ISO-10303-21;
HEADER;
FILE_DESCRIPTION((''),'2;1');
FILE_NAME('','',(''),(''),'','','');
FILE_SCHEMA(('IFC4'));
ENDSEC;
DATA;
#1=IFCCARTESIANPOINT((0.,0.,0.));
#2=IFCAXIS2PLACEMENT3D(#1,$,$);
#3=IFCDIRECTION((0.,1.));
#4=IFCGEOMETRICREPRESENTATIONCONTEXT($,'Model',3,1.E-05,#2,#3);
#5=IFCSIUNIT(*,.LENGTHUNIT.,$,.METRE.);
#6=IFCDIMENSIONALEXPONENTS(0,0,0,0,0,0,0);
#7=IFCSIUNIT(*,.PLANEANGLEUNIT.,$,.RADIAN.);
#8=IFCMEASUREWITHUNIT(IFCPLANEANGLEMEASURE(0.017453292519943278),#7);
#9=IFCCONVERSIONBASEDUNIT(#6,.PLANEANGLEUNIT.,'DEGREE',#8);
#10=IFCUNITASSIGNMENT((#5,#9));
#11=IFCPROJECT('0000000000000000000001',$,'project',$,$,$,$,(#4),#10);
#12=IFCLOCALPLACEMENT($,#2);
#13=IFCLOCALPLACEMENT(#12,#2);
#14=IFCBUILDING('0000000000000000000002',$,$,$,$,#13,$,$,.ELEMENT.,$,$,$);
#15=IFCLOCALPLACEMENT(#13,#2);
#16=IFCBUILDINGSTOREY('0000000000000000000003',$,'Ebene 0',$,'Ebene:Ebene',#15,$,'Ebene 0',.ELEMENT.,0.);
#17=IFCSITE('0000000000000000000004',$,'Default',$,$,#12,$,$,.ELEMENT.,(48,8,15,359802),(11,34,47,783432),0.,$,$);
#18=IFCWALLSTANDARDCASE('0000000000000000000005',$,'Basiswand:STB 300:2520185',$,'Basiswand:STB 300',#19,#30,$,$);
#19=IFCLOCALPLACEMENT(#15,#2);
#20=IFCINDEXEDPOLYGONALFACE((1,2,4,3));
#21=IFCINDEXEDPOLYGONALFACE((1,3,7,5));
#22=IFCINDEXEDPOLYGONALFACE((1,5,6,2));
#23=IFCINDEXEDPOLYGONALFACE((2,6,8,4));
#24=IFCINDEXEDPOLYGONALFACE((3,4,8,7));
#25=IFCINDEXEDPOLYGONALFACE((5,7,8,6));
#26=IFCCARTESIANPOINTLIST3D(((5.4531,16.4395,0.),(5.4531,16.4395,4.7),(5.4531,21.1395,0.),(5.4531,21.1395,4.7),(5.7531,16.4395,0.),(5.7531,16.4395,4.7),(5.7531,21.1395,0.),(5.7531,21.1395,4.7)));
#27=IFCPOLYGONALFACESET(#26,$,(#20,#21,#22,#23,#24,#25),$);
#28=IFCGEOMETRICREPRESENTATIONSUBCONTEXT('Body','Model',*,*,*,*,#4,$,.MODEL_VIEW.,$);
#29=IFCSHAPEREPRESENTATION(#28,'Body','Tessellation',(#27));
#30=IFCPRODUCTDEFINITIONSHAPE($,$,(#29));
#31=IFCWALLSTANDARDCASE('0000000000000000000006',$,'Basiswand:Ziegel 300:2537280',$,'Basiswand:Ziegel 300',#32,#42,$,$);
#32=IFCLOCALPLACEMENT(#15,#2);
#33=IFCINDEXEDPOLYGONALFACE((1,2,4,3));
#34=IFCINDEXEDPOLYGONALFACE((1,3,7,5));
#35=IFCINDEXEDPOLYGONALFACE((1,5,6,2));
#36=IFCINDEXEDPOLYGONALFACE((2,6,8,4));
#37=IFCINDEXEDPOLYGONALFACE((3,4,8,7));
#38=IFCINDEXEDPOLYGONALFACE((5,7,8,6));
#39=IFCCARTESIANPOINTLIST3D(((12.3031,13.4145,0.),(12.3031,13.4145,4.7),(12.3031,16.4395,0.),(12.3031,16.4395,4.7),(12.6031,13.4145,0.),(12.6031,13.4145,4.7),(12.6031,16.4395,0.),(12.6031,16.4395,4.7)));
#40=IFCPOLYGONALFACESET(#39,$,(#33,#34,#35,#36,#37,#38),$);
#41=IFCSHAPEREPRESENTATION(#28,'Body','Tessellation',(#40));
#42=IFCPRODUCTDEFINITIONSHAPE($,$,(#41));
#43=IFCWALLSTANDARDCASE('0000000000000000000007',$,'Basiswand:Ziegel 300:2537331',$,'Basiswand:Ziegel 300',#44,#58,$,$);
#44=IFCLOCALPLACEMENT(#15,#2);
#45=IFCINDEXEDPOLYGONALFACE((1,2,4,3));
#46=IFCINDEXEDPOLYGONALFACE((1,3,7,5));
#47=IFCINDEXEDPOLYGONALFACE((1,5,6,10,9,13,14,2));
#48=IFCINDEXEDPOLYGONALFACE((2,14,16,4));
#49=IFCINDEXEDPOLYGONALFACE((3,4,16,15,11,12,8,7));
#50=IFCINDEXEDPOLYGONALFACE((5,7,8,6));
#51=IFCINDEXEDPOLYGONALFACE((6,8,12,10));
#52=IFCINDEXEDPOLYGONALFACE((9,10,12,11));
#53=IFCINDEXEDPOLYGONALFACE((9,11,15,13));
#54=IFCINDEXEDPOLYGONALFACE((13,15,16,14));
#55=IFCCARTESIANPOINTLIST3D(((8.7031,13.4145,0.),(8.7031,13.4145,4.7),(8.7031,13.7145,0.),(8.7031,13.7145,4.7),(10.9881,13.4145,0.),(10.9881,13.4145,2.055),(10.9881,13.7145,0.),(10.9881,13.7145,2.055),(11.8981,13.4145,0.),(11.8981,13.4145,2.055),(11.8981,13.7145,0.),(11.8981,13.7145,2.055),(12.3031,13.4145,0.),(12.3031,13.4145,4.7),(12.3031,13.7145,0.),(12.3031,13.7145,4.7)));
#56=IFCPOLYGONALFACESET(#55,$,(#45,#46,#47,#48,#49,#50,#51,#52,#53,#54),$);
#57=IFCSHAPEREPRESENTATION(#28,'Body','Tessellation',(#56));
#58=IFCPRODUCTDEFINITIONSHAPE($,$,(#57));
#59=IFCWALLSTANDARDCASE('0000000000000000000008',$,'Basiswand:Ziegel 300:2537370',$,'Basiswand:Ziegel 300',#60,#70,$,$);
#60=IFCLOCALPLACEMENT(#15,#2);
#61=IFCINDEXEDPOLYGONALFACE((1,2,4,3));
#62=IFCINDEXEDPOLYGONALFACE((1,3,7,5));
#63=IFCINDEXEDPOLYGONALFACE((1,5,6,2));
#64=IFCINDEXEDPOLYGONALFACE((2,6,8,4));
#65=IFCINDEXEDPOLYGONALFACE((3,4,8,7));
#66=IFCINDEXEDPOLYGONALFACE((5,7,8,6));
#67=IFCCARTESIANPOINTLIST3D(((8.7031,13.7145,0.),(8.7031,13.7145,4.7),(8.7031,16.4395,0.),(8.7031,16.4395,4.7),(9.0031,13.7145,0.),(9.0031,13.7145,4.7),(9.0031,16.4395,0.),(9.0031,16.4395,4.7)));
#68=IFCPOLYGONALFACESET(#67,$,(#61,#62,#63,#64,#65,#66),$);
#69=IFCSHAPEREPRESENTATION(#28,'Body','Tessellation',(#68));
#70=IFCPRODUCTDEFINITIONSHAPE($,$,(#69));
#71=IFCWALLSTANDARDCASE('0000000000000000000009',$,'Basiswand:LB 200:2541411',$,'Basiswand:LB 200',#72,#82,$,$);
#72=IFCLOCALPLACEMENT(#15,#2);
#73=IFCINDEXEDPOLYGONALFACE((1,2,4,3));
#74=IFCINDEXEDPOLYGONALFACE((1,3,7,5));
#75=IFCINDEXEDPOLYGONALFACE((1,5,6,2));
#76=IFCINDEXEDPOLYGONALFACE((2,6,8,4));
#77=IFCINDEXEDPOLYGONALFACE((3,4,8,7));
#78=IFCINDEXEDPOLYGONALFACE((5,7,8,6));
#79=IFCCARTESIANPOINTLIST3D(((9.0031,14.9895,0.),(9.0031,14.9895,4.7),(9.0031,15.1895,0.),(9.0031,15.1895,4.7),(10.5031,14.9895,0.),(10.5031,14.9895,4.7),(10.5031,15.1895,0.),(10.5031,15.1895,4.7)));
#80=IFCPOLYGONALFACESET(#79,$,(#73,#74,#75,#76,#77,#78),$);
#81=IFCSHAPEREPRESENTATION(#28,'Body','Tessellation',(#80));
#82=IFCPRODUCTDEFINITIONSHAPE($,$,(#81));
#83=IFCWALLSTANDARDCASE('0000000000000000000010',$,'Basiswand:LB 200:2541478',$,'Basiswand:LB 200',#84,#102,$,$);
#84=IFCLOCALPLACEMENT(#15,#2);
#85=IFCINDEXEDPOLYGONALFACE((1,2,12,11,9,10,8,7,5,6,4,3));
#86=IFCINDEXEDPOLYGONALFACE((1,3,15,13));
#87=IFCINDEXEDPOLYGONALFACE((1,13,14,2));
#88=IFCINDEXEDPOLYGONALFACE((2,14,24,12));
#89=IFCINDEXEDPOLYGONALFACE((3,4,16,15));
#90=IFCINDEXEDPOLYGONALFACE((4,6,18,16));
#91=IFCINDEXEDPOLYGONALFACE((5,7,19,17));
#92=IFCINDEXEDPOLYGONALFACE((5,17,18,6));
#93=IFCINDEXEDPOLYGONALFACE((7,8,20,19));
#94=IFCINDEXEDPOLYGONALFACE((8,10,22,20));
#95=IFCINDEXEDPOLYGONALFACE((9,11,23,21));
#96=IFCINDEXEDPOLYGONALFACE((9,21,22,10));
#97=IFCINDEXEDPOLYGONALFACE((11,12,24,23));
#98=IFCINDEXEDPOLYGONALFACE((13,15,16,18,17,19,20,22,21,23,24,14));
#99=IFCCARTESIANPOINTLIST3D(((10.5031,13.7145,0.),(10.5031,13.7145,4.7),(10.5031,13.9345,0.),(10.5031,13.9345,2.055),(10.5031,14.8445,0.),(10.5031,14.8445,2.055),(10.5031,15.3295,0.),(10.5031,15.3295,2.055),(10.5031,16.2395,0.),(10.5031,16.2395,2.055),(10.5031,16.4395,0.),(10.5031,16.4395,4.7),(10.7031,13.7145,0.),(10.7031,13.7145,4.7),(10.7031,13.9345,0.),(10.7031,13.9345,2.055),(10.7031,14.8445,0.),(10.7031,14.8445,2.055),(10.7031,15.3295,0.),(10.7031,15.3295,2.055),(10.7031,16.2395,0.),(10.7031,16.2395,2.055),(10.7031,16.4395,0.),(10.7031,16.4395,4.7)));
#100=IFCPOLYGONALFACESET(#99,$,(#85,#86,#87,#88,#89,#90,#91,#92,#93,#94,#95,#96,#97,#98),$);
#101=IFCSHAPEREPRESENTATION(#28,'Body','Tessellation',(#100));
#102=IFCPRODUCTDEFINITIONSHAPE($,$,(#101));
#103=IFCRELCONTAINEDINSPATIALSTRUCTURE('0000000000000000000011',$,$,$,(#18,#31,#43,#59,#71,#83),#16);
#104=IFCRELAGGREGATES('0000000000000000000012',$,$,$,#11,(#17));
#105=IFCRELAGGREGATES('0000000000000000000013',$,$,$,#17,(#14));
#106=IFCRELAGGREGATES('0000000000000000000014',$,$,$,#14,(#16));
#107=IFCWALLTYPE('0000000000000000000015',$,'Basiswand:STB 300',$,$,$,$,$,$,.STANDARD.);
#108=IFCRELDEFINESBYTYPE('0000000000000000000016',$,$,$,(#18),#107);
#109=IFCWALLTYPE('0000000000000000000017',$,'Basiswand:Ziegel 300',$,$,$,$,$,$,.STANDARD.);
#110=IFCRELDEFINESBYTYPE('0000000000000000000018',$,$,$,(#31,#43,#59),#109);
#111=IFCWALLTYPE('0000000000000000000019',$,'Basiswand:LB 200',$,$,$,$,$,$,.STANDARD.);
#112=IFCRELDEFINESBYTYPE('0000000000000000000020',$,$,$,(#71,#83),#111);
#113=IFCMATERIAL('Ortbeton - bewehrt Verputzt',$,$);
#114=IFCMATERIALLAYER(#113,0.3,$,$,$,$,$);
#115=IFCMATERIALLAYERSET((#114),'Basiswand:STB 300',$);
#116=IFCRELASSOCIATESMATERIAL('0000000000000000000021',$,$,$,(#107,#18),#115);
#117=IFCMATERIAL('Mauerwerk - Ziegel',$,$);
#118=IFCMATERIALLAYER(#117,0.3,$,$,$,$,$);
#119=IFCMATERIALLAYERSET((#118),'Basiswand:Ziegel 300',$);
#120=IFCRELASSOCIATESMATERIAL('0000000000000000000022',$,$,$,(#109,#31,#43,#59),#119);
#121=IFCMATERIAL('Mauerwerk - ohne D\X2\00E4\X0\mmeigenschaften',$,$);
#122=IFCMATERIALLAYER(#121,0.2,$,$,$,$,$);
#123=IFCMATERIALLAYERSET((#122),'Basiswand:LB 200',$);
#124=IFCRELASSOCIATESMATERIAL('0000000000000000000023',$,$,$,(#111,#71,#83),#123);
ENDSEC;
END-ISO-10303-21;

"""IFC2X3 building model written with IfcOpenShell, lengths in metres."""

from ifc_helpers import new_model, entity, si_unit, converted_unit, direction, frame, frame_2d, origin, place, context, subcontext, project, spatial, polyline, rectangle, extrude, clip, bounded_halfspace, material, layer, layer_set, layer_usage, type_object, element, save


model = new_model("IFC2X3")

# Units and contexts
model_context = context("Model", 3, precision=1e-05, world=origin(), true_north=direction((0.0, 1.0)))
body_context = subcontext(model_context, "Body", "Model", "MODEL_VIEW")
ifc_project = project(units=[si_unit("LENGTHUNIT", "METRE"), converted_unit("PLANEANGLEUNIT", "DEGREE", entity("IfcPlaneAngleMeasure", 0.017453292519943278), si_unit("PLANEANGLEUNIT", "RADIAN"), dimensions=[0, 0, 0, 0, 0, 0, 0])], contexts=[model_context])

# Site, building, storey
site_placement = place(None, origin())
site = spatial("IfcSite", under=ifc_project, at=site_placement, Name="Default", CompositionType="ELEMENT", RefLatitude=(48, 8, 15, 359802), RefLongitude=(11, 34, 47, 783432), RefElevation=0.0)
building_placement = place(site_placement, origin())
building = spatial("IfcBuilding", under=site, at=building_placement, CompositionType="ELEMENT")
storey_placement = place(building_placement, origin())
storey = spatial("IfcBuildingStorey", under=building, at=storey_placement, Name="Ebene 0", ObjectType="Ebene:Ebene", LongName="Ebene 0", CompositionType="ELEMENT", Elevation=0.0)

# Shared definitions
ifc_material_1 = material(Name="Ortbeton - bewehrt Verputzt")

# Shared definitions
ifc_layer_1 = layer(ifc_material_1, 0.3)
ifc_layer_set_1 = layer_set([ifc_layer_1], Name="Basiswand:STB 300")
wall_type_1 = type_object("IfcWallType", Name="Basiswand:STB 300", PredefinedType="STANDARD", material=ifc_layer_set_1)

# Walls
ifc_layer_usage_1 = layer_usage(ifc_layer_set_1, "AXIS2", "NEGATIVE", 0.15)
wall_1_placement = place(storey_placement, frame((5.6031, 16.4395, 0.0), z_axis=(0.0, 0.0, 1.0), x_axis=(0.0, 1.0, 0.0)))
element("IfcWallStandardCase", 1, at=wall_1_placement, inside=storey, type_object=wall_type_1, material=ifc_layer_usage_1, Name="Basiswand:STB 300:2520185", ObjectType="Basiswand:STB 300", context=body_context, shape_type="Clipping", body=[
    clip(extrude(rectangle(XDim=4.7, YDim=0.3, at=frame_2d((2.35, 0.0), x_axis=(-1.0, 0.0))), origin(), (0.0, 0.0, 1.0), 4.7), bounded_halfspace(frame((0.0, -0.15, 4.7), z_axis=(0.0, 0.0, -1.0), x_axis=(-1.0, 0.0, 0.0)), True, frame((0.0, -0.15, 4.7)), polyline([(0.0, 0.0), (0.25, 0.0), (4.7, 0.0), (4.7, 0.3), (0.0, 0.3), (0.0, 0.0)]))),
])
ifc_material_2 = material(Name="Mauerwerk - Ziegel")
ifc_layer_2 = layer(ifc_material_2, 0.3)
ifc_layer_set_2 = layer_set([ifc_layer_2], Name="Basiswand:Ziegel 300")
ifc_layer_usage_2 = layer_usage(ifc_layer_set_2, "AXIS2", "NEGATIVE", 0.15)
wall_type_2 = type_object("IfcWallType", Name="Basiswand:Ziegel 300", PredefinedType="STANDARD", material=ifc_layer_set_2)
wall_2_placement = place(storey_placement, frame((12.4531, 16.4395, 0.0), z_axis=(0.0, 0.0, 1.0), x_axis=(0.0, -1.0, 0.0)))
element("IfcWallStandardCase", 2, at=wall_2_placement, inside=storey, type_object=wall_type_2, material=ifc_layer_usage_2, Name="Basiswand:Ziegel 300:2537280", ObjectType="Basiswand:Ziegel 300", context=body_context, shape_type="Clipping", body=[
    clip(extrude(rectangle(XDim=3.025, YDim=0.3, at=frame_2d((1.5125, 0.0), x_axis=(-1.0, 0.0))), origin(), (0.0, 0.0, 1.0), 4.7), bounded_halfspace(frame((0.0, -0.15, 4.7), z_axis=(0.0, 0.0, -1.0), x_axis=(1.0, 0.0, 0.0)), True, frame((0.0, -0.15, 4.7)), polyline([(0.0, 0.0), (2.725, 0.0), (3.025, 0.0), (3.025, 0.3), (0.0, 0.3), (0.0, 0.0)]))),
])

# Wall, opening
ifc_layer_usage_3 = layer_usage(ifc_layer_set_2, "AXIS2", "NEGATIVE", 0.15)
wall_3_placement = place(storey_placement, frame((12.3031, 13.5645, 0.0), z_axis=(0.0, 0.0, 1.0), x_axis=(-1.0, 0.0, 0.0)))
wall_3 = element("IfcWallStandardCase", 3, at=wall_3_placement, inside=storey, type_object=wall_type_2, material=ifc_layer_usage_3, Name="Basiswand:Ziegel 300:2537331", ObjectType="Basiswand:Ziegel 300", context=body_context, shape_type="Clipping", body=[
    clip(extrude(rectangle(XDim=3.6, YDim=0.3, at=frame_2d((1.8, 0.0), x_axis=(-1.0, 0.0))), origin(), (0.0, 0.0, 1.0), 4.7), bounded_halfspace(frame((0.0, -0.15, 4.7), z_axis=(0.0, 0.0, -1.0), x_axis=(0.0, 1.0, 0.0)), True, frame((0.0, -0.15, 4.7)), polyline([(0.0, 0.0), (3.3, 0.0), (3.6, 0.0), (3.6, 0.3), (0.0, 0.3), (0.0, 0.0)]))),
])
opening_1_placement = place(wall_3_placement, frame((1.315, 0.15, -0.18)))
element("IfcOpeningElement", 4, at=opening_1_placement, cuts=wall_3, ObjectType="Opening", context=body_context, shape_type="SweptSolid", body=[
    extrude(rectangle(XDim=2.235, YDim=0.91, at=frame_2d((1.1175, 0.455), x_axis=(-1.0, 0.0))), frame((0.0, 0.0, 0.0), z_axis=(0.0, -1.0, 0.0), x_axis=(0.0, 0.0, 1.0)), (0.0, 0.0, 1.0), 0.3),
])

# Walls
ifc_layer_usage_4 = layer_usage(ifc_layer_set_2, "AXIS2", "NEGATIVE", 0.15)
wall_4_placement = place(storey_placement, frame((8.8531, 13.7145, 0.0), z_axis=(0.0, 0.0, 1.0), x_axis=(0.0, 1.0, 0.0)))
element("IfcWallStandardCase", 5, at=wall_4_placement, inside=storey, type_object=wall_type_2, material=ifc_layer_usage_4, Name="Basiswand:Ziegel 300:2537370", ObjectType="Basiswand:Ziegel 300", context=body_context, shape_type="Clipping", body=[
    clip(extrude(rectangle(XDim=2.725, YDim=0.3, at=frame_2d((1.3625, 0.0), x_axis=(-1.0, 0.0))), origin(), (0.0, 0.0, 1.0), 4.7), bounded_halfspace(frame((0.0, -0.15, 4.7), z_axis=(0.0, 0.0, -1.0), x_axis=(-1.0, 0.0, 0.0)), True, frame((0.0, -0.15, 4.7)), polyline([(0.0, 0.0), (2.725, 0.0), (2.725, 0.3), (0.0, 0.3), (0.0, 0.0)]))),
])
ifc_material_3 = material(Name="Mauerwerk - ohne Dämmeigenschaften")
ifc_layer_3 = layer(ifc_material_3, 0.2)
ifc_layer_set_3 = layer_set([ifc_layer_3], Name="Basiswand:LB 200")
ifc_layer_usage_5 = layer_usage(ifc_layer_set_3, "AXIS2", "NEGATIVE", 0.1)
wall_type_3 = type_object("IfcWallType", Name="Basiswand:LB 200", PredefinedType="STANDARD", material=ifc_layer_set_3)
wall_5_placement = place(storey_placement, frame((9.0031, 15.0895, 0.0)))
element("IfcWallStandardCase", 6, at=wall_5_placement, inside=storey, type_object=wall_type_3, material=ifc_layer_usage_5, Name="Basiswand:LB 200:2541411", ObjectType="Basiswand:LB 200", context=body_context, shape_type="Clipping", body=[
    clip(extrude(rectangle(XDim=1.5, YDim=0.2, at=frame_2d((0.75, 0.0), x_axis=(-1.0, 0.0))), origin(), (0.0, 0.0, 1.0), 4.7), bounded_halfspace(frame((0.0, -0.1, 4.7), z_axis=(0.0, 0.0, -1.0), x_axis=(0.0, -1.0, 0.0)), True, frame((0.0, -0.1, 4.7)), polyline([(0.0, 0.0), (1.5, 0.0), (1.5, 0.2), (0.0, 0.2), (0.0, 0.0)]))),
])

# Wall, openings
ifc_layer_usage_6 = layer_usage(ifc_layer_set_3, "AXIS2", "NEGATIVE", 0.1)
wall_6_placement = place(storey_placement, frame((10.6031, 16.4395, 0.0), z_axis=(0.0, 0.0, 1.0), x_axis=(0.0, -1.0, 0.0)))
wall_6 = element("IfcWallStandardCase", 7, at=wall_6_placement, inside=storey, type_object=wall_type_3, material=ifc_layer_usage_6, Name="Basiswand:LB 200:2541478", ObjectType="Basiswand:LB 200", context=body_context, shape_type="Clipping", body=[
    clip(extrude(rectangle(XDim=2.725, YDim=0.2, at=frame_2d((1.3625, 0.0), x_axis=(1.0, 0.0))), origin(), (0.0, 0.0, 1.0), 4.7), bounded_halfspace(frame((0.0, -0.1, 4.7), z_axis=(0.0, 0.0, -1.0), x_axis=(1.0, 0.0, 0.0)), True, frame((0.0, -0.1, 4.7)), polyline([(0.0, 0.0), (1.25, 0.0), (1.45, 0.0), (2.725, 0.0), (2.725, 0.2), (0.0, 0.2), (0.0, 0.0)]))),
])
opening_2_placement = place(wall_6_placement, frame((1.11, 0.1, -0.18)))
element("IfcOpeningElement", 8, at=opening_2_placement, cuts=wall_6, ObjectType="Opening", context=body_context, shape_type="SweptSolid", body=[
    extrude(rectangle(XDim=2.235, YDim=0.91, at=frame_2d((1.1175, 0.455), x_axis=(-1.0, 0.0))), frame((0.0, 0.0, 0.0), z_axis=(0.0, -1.0, 0.0), x_axis=(0.0, 0.0, 1.0)), (0.0, 0.0, 1.0), 0.2),
])
opening_3_placement = place(wall_6_placement, frame((2.505, 0.1, -0.18)))
element("IfcOpeningElement", 9, at=opening_3_placement, cuts=wall_6, ObjectType="Opening", context=body_context, shape_type="SweptSolid", body=[
    extrude(rectangle(XDim=2.235, YDim=0.91, at=frame_2d((1.1175, 0.455), x_axis=(-1.0, 0.0))), frame((0.0, 0.0, 0.0), z_axis=(0.0, -1.0, 0.0), x_axis=(0.0, 0.0, 1.0)), (0.0, 0.0, 1.0), 0.2),
])

save(model, "model.ifc")
